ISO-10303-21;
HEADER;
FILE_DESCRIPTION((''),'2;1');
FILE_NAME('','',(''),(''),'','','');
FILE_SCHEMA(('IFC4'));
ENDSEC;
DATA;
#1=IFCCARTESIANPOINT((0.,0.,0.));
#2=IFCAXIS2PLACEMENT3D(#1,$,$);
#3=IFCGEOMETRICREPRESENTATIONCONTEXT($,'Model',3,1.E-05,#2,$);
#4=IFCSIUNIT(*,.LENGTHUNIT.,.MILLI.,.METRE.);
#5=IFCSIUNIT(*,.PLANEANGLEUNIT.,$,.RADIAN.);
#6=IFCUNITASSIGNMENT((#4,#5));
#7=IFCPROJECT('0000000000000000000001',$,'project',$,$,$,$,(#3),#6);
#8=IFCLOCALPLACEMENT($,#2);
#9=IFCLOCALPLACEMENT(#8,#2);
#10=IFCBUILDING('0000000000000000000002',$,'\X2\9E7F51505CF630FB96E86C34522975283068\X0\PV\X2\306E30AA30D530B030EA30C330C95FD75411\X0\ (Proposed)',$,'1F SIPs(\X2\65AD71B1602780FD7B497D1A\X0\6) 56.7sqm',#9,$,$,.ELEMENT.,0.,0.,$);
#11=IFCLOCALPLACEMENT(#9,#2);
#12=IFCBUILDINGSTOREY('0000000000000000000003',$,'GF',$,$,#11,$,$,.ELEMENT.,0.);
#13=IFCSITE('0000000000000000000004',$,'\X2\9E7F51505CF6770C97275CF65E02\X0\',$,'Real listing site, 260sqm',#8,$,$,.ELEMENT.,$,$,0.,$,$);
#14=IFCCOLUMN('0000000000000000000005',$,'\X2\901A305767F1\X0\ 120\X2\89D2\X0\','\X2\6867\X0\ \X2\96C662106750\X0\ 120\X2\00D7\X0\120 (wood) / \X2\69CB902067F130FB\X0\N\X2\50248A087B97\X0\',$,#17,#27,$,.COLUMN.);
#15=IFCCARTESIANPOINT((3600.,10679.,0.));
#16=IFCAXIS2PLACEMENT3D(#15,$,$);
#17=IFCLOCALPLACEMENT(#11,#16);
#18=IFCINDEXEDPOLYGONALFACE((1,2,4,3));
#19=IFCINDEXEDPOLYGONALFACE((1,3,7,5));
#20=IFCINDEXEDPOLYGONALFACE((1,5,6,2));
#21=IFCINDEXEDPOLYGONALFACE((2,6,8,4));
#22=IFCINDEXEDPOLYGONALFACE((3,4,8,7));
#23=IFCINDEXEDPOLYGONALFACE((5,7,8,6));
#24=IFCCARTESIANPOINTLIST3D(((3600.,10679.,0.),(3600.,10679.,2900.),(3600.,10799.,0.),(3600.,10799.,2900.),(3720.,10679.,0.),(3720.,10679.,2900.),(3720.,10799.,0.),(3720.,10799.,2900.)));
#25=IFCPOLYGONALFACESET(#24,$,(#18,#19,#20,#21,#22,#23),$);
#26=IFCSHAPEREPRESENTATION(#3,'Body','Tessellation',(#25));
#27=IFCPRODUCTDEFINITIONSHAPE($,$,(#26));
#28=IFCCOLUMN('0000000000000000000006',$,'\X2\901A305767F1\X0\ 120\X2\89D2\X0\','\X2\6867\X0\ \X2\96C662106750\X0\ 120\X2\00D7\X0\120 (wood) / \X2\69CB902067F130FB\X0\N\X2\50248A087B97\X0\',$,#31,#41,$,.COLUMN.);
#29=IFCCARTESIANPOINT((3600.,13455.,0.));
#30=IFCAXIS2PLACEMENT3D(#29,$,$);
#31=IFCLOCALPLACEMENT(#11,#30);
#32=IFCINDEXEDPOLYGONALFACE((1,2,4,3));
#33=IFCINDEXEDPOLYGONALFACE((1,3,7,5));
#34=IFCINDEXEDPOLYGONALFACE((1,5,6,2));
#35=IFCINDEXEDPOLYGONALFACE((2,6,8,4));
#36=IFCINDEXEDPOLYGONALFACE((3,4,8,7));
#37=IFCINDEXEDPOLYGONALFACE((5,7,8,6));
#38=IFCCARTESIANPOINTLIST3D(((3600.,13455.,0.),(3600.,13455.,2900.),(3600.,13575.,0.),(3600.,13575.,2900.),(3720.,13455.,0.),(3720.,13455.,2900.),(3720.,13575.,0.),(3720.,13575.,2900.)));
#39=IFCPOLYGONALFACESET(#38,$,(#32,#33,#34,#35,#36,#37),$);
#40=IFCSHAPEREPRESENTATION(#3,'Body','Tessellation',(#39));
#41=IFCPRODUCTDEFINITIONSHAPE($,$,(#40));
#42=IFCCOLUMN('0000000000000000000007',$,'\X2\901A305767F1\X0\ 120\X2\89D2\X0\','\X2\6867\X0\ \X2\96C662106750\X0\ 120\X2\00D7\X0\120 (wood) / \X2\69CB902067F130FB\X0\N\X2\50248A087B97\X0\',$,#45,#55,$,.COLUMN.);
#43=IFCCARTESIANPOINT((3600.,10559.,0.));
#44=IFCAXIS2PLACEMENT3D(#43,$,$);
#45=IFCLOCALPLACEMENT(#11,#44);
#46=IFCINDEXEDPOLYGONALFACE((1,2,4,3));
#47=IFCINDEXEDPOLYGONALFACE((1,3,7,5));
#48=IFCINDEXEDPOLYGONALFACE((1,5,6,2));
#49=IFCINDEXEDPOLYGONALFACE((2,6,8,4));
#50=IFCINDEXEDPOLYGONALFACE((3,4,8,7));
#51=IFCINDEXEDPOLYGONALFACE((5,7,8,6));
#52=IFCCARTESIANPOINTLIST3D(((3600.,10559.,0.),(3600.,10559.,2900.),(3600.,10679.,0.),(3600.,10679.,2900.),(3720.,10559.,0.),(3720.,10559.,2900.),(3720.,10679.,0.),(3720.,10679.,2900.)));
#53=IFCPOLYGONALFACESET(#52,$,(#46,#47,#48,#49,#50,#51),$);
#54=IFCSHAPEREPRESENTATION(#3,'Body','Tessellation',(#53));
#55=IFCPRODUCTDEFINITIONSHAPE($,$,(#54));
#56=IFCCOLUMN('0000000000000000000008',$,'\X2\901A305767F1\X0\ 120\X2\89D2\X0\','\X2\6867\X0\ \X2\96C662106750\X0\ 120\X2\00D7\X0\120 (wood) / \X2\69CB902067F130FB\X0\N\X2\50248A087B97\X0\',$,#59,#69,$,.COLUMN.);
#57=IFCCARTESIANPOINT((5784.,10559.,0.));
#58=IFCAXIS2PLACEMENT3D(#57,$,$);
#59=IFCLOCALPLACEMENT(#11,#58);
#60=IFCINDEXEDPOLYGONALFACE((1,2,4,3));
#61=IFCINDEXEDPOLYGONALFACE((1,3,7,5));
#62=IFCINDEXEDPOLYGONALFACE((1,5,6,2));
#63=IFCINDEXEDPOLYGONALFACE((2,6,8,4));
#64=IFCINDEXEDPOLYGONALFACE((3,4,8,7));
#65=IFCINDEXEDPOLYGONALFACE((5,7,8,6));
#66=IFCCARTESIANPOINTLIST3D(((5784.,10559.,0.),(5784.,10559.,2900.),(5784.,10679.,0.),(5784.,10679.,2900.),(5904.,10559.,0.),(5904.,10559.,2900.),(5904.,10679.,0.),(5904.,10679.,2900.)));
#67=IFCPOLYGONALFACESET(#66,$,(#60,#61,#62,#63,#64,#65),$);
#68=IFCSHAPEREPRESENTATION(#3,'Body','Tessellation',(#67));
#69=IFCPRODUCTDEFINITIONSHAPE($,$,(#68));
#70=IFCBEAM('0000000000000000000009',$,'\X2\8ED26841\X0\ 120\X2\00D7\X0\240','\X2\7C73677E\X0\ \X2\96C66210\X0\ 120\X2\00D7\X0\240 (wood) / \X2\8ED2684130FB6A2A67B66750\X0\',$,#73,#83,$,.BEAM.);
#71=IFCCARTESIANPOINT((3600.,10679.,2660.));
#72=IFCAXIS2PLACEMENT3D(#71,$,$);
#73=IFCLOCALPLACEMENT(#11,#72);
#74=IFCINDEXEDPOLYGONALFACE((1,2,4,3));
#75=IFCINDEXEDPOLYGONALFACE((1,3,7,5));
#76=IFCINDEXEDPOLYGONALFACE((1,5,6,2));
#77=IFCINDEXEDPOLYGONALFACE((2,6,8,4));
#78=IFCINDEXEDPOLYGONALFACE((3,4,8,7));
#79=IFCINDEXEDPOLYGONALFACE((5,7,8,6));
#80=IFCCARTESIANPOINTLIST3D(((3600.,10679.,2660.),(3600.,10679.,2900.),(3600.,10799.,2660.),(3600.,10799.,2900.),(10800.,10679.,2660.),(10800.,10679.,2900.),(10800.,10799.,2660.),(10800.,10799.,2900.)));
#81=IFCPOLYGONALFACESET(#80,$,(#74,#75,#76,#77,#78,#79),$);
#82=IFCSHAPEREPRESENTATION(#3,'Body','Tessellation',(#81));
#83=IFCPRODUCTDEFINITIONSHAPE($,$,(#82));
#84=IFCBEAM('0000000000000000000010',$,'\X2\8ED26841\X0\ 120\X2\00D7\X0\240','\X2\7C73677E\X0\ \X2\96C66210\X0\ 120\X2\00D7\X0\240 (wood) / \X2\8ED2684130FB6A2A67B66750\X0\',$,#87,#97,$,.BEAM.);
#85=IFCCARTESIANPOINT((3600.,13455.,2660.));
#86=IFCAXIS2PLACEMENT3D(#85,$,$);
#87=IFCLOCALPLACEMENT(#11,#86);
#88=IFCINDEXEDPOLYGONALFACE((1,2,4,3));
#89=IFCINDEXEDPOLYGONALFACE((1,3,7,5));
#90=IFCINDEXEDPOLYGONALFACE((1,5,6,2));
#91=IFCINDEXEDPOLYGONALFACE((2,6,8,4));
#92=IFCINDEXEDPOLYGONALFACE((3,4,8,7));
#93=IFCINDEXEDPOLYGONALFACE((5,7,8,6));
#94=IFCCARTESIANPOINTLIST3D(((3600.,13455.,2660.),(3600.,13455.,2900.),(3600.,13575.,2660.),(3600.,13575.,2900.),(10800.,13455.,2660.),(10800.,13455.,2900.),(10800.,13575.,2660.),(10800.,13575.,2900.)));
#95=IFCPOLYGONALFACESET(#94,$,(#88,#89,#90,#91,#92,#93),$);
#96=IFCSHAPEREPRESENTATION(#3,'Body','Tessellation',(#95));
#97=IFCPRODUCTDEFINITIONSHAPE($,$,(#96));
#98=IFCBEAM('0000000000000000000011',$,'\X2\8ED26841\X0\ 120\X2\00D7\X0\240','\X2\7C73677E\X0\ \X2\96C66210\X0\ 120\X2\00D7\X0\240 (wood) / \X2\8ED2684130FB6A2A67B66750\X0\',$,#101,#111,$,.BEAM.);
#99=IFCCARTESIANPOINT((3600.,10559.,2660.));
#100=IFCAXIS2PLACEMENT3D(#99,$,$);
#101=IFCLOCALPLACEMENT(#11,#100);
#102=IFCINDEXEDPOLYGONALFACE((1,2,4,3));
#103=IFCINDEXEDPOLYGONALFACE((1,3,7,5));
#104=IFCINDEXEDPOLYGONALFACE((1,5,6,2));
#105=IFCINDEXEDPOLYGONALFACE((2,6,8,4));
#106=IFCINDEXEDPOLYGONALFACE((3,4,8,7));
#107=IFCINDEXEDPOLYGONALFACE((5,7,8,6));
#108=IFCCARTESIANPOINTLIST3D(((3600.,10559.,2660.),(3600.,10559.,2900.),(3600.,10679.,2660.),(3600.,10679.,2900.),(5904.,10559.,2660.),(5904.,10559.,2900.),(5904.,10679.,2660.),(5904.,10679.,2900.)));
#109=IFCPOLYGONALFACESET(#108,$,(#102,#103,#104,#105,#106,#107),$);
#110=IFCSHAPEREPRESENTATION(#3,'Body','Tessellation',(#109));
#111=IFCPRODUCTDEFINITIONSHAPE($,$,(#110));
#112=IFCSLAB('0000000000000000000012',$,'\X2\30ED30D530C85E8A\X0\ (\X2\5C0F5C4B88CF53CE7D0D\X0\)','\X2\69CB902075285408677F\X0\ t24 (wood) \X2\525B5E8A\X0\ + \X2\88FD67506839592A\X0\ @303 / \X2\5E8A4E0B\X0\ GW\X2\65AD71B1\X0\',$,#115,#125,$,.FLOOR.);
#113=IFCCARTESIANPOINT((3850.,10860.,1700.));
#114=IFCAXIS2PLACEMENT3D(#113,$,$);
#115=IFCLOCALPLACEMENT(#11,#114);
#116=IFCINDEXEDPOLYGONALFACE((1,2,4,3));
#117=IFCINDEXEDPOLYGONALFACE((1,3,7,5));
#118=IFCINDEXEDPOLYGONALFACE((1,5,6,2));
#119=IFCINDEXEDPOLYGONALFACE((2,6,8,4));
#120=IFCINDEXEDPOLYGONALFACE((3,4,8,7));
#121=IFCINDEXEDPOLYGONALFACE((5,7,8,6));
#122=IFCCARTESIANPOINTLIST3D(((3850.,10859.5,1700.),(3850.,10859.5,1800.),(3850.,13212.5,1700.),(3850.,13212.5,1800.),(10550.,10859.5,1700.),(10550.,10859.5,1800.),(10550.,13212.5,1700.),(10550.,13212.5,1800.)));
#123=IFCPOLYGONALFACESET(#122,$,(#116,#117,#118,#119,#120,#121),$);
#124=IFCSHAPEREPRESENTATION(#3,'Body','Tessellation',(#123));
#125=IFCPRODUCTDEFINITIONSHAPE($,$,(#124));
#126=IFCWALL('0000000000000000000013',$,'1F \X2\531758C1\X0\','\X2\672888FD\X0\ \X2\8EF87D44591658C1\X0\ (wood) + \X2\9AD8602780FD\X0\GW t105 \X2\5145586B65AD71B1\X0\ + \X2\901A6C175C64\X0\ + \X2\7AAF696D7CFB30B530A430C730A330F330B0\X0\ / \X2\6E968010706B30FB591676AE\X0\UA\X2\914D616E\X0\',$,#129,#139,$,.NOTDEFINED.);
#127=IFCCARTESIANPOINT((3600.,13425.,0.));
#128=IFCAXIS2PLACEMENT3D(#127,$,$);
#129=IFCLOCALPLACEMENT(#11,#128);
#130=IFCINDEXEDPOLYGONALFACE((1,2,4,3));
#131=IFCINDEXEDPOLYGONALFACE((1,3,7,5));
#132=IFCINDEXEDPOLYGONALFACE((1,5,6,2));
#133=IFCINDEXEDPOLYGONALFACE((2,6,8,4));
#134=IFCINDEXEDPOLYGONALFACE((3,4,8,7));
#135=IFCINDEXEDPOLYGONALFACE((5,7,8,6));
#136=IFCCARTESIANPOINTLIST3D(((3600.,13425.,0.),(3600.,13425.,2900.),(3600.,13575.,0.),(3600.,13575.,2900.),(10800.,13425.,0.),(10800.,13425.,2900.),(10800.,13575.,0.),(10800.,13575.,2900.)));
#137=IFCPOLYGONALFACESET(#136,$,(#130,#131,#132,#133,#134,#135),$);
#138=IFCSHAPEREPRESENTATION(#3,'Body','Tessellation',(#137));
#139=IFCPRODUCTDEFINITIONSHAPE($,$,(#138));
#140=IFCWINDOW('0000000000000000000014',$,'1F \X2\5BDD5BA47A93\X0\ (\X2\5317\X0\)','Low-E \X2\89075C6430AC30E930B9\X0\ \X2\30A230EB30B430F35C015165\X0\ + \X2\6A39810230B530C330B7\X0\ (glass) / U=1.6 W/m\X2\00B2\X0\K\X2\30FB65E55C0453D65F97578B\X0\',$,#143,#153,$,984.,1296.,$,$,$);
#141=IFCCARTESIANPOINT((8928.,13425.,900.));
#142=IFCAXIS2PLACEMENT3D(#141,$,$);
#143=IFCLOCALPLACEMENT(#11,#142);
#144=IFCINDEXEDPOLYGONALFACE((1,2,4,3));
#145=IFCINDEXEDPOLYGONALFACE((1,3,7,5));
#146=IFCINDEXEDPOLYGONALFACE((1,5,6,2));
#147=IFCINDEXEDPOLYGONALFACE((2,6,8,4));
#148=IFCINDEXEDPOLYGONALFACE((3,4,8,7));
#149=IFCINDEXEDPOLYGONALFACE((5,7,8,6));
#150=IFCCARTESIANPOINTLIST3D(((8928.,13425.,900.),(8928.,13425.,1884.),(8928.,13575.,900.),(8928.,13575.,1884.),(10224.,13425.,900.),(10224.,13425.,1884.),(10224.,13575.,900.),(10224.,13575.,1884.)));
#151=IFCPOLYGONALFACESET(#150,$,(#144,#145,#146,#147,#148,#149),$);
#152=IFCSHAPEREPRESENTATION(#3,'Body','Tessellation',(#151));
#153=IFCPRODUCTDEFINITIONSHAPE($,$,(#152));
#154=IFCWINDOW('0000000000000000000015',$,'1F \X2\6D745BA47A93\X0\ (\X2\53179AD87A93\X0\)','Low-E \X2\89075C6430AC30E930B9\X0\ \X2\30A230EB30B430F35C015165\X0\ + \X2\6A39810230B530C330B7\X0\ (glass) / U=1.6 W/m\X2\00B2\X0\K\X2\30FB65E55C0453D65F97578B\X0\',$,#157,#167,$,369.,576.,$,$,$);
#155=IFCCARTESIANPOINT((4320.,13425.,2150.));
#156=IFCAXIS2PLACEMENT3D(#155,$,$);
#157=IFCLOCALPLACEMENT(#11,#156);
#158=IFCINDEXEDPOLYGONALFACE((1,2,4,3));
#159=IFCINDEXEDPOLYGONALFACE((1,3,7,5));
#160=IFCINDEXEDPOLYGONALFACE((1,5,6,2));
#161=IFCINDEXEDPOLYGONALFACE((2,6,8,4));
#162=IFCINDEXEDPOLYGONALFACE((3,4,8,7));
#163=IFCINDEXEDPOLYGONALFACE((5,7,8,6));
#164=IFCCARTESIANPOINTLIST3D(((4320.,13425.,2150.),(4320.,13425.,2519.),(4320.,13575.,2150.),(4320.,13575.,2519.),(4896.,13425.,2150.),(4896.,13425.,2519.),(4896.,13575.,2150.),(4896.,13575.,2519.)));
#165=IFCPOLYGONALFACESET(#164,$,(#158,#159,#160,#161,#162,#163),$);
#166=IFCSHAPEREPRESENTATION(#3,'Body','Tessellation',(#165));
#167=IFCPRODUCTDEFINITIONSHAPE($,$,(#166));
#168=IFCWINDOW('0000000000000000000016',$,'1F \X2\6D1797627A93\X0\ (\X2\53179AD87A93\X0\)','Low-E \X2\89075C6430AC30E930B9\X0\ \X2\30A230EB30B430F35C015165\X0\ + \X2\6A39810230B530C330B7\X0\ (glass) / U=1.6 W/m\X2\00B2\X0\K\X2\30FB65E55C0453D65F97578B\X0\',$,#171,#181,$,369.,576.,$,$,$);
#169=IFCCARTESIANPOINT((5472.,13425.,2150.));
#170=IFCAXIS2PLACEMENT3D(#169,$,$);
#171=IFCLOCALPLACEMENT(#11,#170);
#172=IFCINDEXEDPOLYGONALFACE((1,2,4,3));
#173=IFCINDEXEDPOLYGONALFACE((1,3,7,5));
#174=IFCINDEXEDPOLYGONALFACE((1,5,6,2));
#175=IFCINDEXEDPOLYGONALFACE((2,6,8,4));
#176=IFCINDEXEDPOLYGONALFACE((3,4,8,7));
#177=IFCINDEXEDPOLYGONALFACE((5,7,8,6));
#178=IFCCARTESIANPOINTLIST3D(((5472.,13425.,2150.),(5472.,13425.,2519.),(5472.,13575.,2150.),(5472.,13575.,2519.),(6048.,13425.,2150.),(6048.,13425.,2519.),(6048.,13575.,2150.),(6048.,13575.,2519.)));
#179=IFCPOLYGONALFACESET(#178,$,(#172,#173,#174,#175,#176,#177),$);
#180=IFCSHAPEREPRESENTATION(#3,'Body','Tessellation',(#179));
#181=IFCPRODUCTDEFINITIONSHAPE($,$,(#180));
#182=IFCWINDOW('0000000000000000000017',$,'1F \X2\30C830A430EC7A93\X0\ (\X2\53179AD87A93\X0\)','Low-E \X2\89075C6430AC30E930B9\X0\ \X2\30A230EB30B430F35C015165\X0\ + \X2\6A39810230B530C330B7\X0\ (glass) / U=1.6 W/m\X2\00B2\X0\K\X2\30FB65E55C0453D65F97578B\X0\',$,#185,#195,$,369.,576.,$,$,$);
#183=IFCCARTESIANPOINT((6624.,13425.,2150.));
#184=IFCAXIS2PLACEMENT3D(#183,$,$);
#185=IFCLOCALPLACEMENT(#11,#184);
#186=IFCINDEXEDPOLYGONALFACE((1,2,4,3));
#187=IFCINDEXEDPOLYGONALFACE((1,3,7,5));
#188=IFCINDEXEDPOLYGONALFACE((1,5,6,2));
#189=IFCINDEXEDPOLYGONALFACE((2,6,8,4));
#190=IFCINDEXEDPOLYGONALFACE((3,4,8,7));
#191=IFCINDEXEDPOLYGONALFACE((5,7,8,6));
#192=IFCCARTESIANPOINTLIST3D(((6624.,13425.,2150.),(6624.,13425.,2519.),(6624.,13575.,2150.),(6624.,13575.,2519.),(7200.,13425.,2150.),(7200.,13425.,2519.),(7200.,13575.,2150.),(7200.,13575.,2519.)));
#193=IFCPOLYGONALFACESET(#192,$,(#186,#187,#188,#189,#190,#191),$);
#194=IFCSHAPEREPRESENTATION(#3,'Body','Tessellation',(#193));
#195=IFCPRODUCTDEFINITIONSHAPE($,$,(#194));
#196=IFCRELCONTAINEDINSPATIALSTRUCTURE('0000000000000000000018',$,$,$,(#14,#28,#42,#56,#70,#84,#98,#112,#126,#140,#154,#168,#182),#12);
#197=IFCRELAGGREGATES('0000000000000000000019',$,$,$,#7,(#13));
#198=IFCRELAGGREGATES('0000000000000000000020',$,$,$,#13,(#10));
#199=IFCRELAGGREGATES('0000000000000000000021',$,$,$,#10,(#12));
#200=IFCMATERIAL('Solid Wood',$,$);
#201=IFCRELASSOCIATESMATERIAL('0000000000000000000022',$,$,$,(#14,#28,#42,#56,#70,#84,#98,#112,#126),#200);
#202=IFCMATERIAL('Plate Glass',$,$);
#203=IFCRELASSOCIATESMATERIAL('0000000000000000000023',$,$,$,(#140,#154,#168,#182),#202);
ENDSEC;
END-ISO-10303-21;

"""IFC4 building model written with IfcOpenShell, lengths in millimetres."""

from ifc_helpers import new_model, si_unit, frame, frame_2d, origin, place, context, project, spatial, rectangle, extrude, material, element, fill, save


model = new_model("IFC4")

# Units and contexts
model_context = context("Model", 3, precision=1e-05, world=origin())
ifc_project = project(units=[si_unit("LENGTHUNIT", "METRE", prefix="MILLI"), si_unit("PLANEANGLEUNIT", "RADIAN")], contexts=[model_context])

# Site, building, storey
site_placement = place(None, origin())
site = spatial("IfcSite", under=ifc_project, at=site_placement, Name="鹿児島県霧島市", ObjectType="Real listing site, 260sqm", CompositionType="ELEMENT", RefElevation=0.0)
building_placement = place(site_placement, origin())
building = spatial("IfcBuilding", under=site, at=building_placement, Name="鹿児島・雨水利用とPVのオフグリッド志向 (Proposed)", ObjectType="1F SIPs(断熱性能等級6) 56.7sqm", CompositionType="ELEMENT", ElevationOfRefHeight=0.0, ElevationOfTerrain=0.0)
storey_placement = place(building_placement, origin())
storey = spatial("IfcBuildingStorey", under=building, at=storey_placement, Name="GF", CompositionType="ELEMENT", Elevation=0.0)

# Columns
ifc_material_1 = material(Name="Solid Wood")
column_1_placement = place(storey_placement, frame((3600.0, 10679.0, 0.0)))
element("IfcColumn", 1, at=column_1_placement, inside=storey, material=ifc_material_1, Name="通し柱 120角", Description="桧 集成材 120×120 (wood) / 構造柱・N値計算", PredefinedType="COLUMN", context=model_context, shape_type="SweptSolid", body=[
    extrude(rectangle(XDim=120.0, YDim=120.0, at=frame_2d((60.0, 60.0))), frame((3600.0, 10679.0, 0.0)), (0.0, 0.0, 1.0), 2900.0),
])
column_2_placement = place(storey_placement, frame((3600.0, 13455.0, 0.0)))
element("IfcColumn", 2, at=column_2_placement, inside=storey, material=ifc_material_1, Name="通し柱 120角", Description="桧 集成材 120×120 (wood) / 構造柱・N値計算", PredefinedType="COLUMN", context=model_context, shape_type="SweptSolid", body=[
    extrude(rectangle(XDim=120.0, YDim=120.0, at=frame_2d((60.0, 60.0))), frame((3600.0, 13455.0, 0.0)), (0.0, 0.0, 1.0), 2900.0),
])
column_3_placement = place(storey_placement, frame((3600.0, 10559.0, 0.0)))
element("IfcColumn", 3, at=column_3_placement, inside=storey, material=ifc_material_1, Name="通し柱 120角", Description="桧 集成材 120×120 (wood) / 構造柱・N値計算", PredefinedType="COLUMN", context=model_context, shape_type="SweptSolid", body=[
    extrude(rectangle(XDim=120.0, YDim=120.0, at=frame_2d((60.0, 60.0))), frame((3600.0, 10559.0, 0.0)), (0.0, 0.0, 1.0), 2900.0),
])
column_4_placement = place(storey_placement, frame((5784.0, 10559.0, 0.0)))
element("IfcColumn", 4, at=column_4_placement, inside=storey, material=ifc_material_1, Name="通し柱 120角", Description="桧 集成材 120×120 (wood) / 構造柱・N値計算", PredefinedType="COLUMN", context=model_context, shape_type="SweptSolid", body=[
    extrude(rectangle(XDim=120.0, YDim=120.0, at=frame_2d((60.0, 60.0))), frame((5784.0, 10559.0, 0.0)), (0.0, 0.0, 1.0), 2900.0),
])

# Beams
beam_1_placement = place(storey_placement, frame((3600.0, 10679.0, 2660.0)))
element("IfcBeam", 5, at=beam_1_placement, inside=storey, material=ifc_material_1, Name="軒桁 120×240", Description="米松 集成 120×240 (wood) / 軒桁・横架材", PredefinedType="BEAM", context=model_context, shape_type="SweptSolid", body=[
    extrude(rectangle(XDim=7200.0, YDim=120.0, at=frame_2d((3600.0, 60.0))), frame((3600.0, 10679.0, 2660.0)), (0.0, 0.0, 1.0), 240.0),
])
beam_2_placement = place(storey_placement, frame((3600.0, 13455.0, 2660.0)))
element("IfcBeam", 6, at=beam_2_placement, inside=storey, material=ifc_material_1, Name="軒桁 120×240", Description="米松 集成 120×240 (wood) / 軒桁・横架材", PredefinedType="BEAM", context=model_context, shape_type="SweptSolid", body=[
    extrude(rectangle(XDim=7200.0, YDim=120.0, at=frame_2d((3600.0, 60.0))), frame((3600.0, 13455.0, 2660.0)), (0.0, 0.0, 1.0), 240.0),
])
beam_3_placement = place(storey_placement, frame((3600.0, 10559.0, 2660.0)))
element("IfcBeam", 7, at=beam_3_placement, inside=storey, material=ifc_material_1, Name="軒桁 120×240", Description="米松 集成 120×240 (wood) / 軒桁・横架材", PredefinedType="BEAM", context=model_context, shape_type="SweptSolid", body=[
    extrude(rectangle(XDim=2304.0, YDim=120.0, at=frame_2d((1152.0, 60.0))), frame((3600.0, 10559.0, 2660.0)), (0.0, 0.0, 1.0), 240.0),
])

# Slab
slab_1_placement = place(storey_placement, frame((3850.0, 10860.0, 1700.0)))
element("IfcSlab", 8, at=slab_1_placement, inside=storey, material=ifc_material_1, Name="ロフト床 (小屋裏収納)", Description="構造用合板 t24 (wood) 剛床 + 製材根太 @303 / 床下 GW断熱", PredefinedType="FLOOR", context=model_context, shape_type="SweptSolid", body=[
    extrude(rectangle(XDim=6700.0, YDim=2353.0, at=frame_2d((3350.0, 1176.0))), frame((3850.0, 10860.0, 1700.0)), (0.0, 0.0, 1.0), 100.0),
])

# Wall, openings, windows
wall_1_placement = place(storey_placement, frame((3600.0, 13425.0, 0.0)))
wall_1 = element("IfcWall", 9, at=wall_1_placement, inside=storey, material=ifc_material_1, Name="1F 北壁", Description="木製 軸組外壁 (wood) + 高性能GW t105 充填断熱 + 通気層 + 窯業系サイディング / 準耐火・外皮UA配慮", PredefinedType="NOTDEFINED", context=model_context, shape_type="SweptSolid", body=[
    extrude(rectangle(XDim=7200.0, YDim=150.0, at=frame_2d((3600.0, 75.0))), frame((3600.0, 13425.0, 0.0)), (0.0, 0.0, 1.0), 2900.0),
])
opening_1_placement = place(storey_placement, frame((8928.0, 13425.0, 900.0)))
opening_1 = element("IfcOpeningElement", 10, at=opening_1_placement, cuts=wall_1, PredefinedType="NOTDEFINED", context=model_context, shape_type="SweptSolid", body=[
    extrude(rectangle(XDim=1296.0, YDim=150.0, at=frame_2d((648.0, 75.0))), frame((8928.0, 13425.0, 900.0)), (0.0, 0.0, 1.0), 984.0),
])
opening_2_placement = place(storey_placement, frame((4320.0, 13425.0, 2150.0)))
opening_2 = element("IfcOpeningElement", 11, at=opening_2_placement, cuts=wall_1, PredefinedType="NOTDEFINED", context=model_context, shape_type="SweptSolid", body=[
    extrude(rectangle(XDim=576.0, YDim=150.0, at=frame_2d((288.0, 75.0))), frame((4320.0, 13425.0, 2150.0)), (0.0, 0.0, 1.0), 369.0),
])
opening_3_placement = place(storey_placement, frame((5472.0, 13425.0, 2150.0)))
opening_3 = element("IfcOpeningElement", 12, at=opening_3_placement, cuts=wall_1, PredefinedType="NOTDEFINED", context=model_context, shape_type="SweptSolid", body=[
    extrude(rectangle(XDim=576.0, YDim=150.0, at=frame_2d((288.0, 75.0))), frame((5472.0, 13425.0, 2150.0)), (0.0, 0.0, 1.0), 369.0),
])
opening_4_placement = place(storey_placement, frame((6624.0, 13425.0, 2150.0)))
opening_4 = element("IfcOpeningElement", 13, at=opening_4_placement, cuts=wall_1, PredefinedType="NOTDEFINED", context=model_context, shape_type="SweptSolid", body=[
    extrude(rectangle(XDim=576.0, YDim=150.0, at=frame_2d((288.0, 75.0))), frame((6624.0, 13425.0, 2150.0)), (0.0, 0.0, 1.0), 369.0),
])
ifc_material_2 = material(Name="Plate Glass")
window_1_placement = place(storey_placement, frame((8928.0, 13425.0, 900.0)))
window_1 = element("IfcWindow", 14, at=window_1_placement, inside=storey, material=ifc_material_2, Name="1F 寝室窓 (北)", Description="Low-E 複層ガラス アルゴン封入 + 樹脂サッシ (glass) / U=1.6 W/m²K・日射取得型", OverallHeight=984.0, OverallWidth=1296.0, context=model_context, shape_type="SweptSolid", body=[
    extrude(rectangle(XDim=1296.0, YDim=150.0, at=frame_2d((648.0, 75.0))), frame((8928.0, 13425.0, 900.0)), (0.0, 0.0, 1.0), 984.0),
])
fill(opening_1, window_1)
window_2_placement = place(storey_placement, frame((4320.0, 13425.0, 2150.0)))
window_2 = element("IfcWindow", 15, at=window_2_placement, inside=storey, material=ifc_material_2, Name="1F 浴室窓 (北高窓)", Description="Low-E 複層ガラス アルゴン封入 + 樹脂サッシ (glass) / U=1.6 W/m²K・日射取得型", OverallHeight=369.0, OverallWidth=576.0, context=model_context, shape_type="SweptSolid", body=[
    extrude(rectangle(XDim=576.0, YDim=150.0, at=frame_2d((288.0, 75.0))), frame((4320.0, 13425.0, 2150.0)), (0.0, 0.0, 1.0), 369.0),
])
fill(opening_2, window_2)
window_3_placement = place(storey_placement, frame((5472.0, 13425.0, 2150.0)))
window_3 = element("IfcWindow", 16, at=window_3_placement, inside=storey, material=ifc_material_2, Name="1F 洗面窓 (北高窓)", Description="Low-E 複層ガラス アルゴン封入 + 樹脂サッシ (glass) / U=1.6 W/m²K・日射取得型", OverallHeight=369.0, OverallWidth=576.0, context=model_context, shape_type="SweptSolid", body=[
    extrude(rectangle(XDim=576.0, YDim=150.0, at=frame_2d((288.0, 75.0))), frame((5472.0, 13425.0, 2150.0)), (0.0, 0.0, 1.0), 369.0),
])
fill(opening_3, window_3)
window_4_placement = place(storey_placement, frame((6624.0, 13425.0, 2150.0)))
window_4 = element("IfcWindow", 17, at=window_4_placement, inside=storey, material=ifc_material_2, Name="1F トイレ窓 (北高窓)", Description="Low-E 複層ガラス アルゴン封入 + 樹脂サッシ (glass) / U=1.6 W/m²K・日射取得型", OverallHeight=369.0, OverallWidth=576.0, context=model_context, shape_type="SweptSolid", body=[
    extrude(rectangle(XDim=576.0, YDim=150.0, at=frame_2d((288.0, 75.0))), frame((6624.0, 13425.0, 2150.0)), (0.0, 0.0, 1.0), 369.0),
])
fill(opening_4, window_4)

save(model, "model.ifc")
